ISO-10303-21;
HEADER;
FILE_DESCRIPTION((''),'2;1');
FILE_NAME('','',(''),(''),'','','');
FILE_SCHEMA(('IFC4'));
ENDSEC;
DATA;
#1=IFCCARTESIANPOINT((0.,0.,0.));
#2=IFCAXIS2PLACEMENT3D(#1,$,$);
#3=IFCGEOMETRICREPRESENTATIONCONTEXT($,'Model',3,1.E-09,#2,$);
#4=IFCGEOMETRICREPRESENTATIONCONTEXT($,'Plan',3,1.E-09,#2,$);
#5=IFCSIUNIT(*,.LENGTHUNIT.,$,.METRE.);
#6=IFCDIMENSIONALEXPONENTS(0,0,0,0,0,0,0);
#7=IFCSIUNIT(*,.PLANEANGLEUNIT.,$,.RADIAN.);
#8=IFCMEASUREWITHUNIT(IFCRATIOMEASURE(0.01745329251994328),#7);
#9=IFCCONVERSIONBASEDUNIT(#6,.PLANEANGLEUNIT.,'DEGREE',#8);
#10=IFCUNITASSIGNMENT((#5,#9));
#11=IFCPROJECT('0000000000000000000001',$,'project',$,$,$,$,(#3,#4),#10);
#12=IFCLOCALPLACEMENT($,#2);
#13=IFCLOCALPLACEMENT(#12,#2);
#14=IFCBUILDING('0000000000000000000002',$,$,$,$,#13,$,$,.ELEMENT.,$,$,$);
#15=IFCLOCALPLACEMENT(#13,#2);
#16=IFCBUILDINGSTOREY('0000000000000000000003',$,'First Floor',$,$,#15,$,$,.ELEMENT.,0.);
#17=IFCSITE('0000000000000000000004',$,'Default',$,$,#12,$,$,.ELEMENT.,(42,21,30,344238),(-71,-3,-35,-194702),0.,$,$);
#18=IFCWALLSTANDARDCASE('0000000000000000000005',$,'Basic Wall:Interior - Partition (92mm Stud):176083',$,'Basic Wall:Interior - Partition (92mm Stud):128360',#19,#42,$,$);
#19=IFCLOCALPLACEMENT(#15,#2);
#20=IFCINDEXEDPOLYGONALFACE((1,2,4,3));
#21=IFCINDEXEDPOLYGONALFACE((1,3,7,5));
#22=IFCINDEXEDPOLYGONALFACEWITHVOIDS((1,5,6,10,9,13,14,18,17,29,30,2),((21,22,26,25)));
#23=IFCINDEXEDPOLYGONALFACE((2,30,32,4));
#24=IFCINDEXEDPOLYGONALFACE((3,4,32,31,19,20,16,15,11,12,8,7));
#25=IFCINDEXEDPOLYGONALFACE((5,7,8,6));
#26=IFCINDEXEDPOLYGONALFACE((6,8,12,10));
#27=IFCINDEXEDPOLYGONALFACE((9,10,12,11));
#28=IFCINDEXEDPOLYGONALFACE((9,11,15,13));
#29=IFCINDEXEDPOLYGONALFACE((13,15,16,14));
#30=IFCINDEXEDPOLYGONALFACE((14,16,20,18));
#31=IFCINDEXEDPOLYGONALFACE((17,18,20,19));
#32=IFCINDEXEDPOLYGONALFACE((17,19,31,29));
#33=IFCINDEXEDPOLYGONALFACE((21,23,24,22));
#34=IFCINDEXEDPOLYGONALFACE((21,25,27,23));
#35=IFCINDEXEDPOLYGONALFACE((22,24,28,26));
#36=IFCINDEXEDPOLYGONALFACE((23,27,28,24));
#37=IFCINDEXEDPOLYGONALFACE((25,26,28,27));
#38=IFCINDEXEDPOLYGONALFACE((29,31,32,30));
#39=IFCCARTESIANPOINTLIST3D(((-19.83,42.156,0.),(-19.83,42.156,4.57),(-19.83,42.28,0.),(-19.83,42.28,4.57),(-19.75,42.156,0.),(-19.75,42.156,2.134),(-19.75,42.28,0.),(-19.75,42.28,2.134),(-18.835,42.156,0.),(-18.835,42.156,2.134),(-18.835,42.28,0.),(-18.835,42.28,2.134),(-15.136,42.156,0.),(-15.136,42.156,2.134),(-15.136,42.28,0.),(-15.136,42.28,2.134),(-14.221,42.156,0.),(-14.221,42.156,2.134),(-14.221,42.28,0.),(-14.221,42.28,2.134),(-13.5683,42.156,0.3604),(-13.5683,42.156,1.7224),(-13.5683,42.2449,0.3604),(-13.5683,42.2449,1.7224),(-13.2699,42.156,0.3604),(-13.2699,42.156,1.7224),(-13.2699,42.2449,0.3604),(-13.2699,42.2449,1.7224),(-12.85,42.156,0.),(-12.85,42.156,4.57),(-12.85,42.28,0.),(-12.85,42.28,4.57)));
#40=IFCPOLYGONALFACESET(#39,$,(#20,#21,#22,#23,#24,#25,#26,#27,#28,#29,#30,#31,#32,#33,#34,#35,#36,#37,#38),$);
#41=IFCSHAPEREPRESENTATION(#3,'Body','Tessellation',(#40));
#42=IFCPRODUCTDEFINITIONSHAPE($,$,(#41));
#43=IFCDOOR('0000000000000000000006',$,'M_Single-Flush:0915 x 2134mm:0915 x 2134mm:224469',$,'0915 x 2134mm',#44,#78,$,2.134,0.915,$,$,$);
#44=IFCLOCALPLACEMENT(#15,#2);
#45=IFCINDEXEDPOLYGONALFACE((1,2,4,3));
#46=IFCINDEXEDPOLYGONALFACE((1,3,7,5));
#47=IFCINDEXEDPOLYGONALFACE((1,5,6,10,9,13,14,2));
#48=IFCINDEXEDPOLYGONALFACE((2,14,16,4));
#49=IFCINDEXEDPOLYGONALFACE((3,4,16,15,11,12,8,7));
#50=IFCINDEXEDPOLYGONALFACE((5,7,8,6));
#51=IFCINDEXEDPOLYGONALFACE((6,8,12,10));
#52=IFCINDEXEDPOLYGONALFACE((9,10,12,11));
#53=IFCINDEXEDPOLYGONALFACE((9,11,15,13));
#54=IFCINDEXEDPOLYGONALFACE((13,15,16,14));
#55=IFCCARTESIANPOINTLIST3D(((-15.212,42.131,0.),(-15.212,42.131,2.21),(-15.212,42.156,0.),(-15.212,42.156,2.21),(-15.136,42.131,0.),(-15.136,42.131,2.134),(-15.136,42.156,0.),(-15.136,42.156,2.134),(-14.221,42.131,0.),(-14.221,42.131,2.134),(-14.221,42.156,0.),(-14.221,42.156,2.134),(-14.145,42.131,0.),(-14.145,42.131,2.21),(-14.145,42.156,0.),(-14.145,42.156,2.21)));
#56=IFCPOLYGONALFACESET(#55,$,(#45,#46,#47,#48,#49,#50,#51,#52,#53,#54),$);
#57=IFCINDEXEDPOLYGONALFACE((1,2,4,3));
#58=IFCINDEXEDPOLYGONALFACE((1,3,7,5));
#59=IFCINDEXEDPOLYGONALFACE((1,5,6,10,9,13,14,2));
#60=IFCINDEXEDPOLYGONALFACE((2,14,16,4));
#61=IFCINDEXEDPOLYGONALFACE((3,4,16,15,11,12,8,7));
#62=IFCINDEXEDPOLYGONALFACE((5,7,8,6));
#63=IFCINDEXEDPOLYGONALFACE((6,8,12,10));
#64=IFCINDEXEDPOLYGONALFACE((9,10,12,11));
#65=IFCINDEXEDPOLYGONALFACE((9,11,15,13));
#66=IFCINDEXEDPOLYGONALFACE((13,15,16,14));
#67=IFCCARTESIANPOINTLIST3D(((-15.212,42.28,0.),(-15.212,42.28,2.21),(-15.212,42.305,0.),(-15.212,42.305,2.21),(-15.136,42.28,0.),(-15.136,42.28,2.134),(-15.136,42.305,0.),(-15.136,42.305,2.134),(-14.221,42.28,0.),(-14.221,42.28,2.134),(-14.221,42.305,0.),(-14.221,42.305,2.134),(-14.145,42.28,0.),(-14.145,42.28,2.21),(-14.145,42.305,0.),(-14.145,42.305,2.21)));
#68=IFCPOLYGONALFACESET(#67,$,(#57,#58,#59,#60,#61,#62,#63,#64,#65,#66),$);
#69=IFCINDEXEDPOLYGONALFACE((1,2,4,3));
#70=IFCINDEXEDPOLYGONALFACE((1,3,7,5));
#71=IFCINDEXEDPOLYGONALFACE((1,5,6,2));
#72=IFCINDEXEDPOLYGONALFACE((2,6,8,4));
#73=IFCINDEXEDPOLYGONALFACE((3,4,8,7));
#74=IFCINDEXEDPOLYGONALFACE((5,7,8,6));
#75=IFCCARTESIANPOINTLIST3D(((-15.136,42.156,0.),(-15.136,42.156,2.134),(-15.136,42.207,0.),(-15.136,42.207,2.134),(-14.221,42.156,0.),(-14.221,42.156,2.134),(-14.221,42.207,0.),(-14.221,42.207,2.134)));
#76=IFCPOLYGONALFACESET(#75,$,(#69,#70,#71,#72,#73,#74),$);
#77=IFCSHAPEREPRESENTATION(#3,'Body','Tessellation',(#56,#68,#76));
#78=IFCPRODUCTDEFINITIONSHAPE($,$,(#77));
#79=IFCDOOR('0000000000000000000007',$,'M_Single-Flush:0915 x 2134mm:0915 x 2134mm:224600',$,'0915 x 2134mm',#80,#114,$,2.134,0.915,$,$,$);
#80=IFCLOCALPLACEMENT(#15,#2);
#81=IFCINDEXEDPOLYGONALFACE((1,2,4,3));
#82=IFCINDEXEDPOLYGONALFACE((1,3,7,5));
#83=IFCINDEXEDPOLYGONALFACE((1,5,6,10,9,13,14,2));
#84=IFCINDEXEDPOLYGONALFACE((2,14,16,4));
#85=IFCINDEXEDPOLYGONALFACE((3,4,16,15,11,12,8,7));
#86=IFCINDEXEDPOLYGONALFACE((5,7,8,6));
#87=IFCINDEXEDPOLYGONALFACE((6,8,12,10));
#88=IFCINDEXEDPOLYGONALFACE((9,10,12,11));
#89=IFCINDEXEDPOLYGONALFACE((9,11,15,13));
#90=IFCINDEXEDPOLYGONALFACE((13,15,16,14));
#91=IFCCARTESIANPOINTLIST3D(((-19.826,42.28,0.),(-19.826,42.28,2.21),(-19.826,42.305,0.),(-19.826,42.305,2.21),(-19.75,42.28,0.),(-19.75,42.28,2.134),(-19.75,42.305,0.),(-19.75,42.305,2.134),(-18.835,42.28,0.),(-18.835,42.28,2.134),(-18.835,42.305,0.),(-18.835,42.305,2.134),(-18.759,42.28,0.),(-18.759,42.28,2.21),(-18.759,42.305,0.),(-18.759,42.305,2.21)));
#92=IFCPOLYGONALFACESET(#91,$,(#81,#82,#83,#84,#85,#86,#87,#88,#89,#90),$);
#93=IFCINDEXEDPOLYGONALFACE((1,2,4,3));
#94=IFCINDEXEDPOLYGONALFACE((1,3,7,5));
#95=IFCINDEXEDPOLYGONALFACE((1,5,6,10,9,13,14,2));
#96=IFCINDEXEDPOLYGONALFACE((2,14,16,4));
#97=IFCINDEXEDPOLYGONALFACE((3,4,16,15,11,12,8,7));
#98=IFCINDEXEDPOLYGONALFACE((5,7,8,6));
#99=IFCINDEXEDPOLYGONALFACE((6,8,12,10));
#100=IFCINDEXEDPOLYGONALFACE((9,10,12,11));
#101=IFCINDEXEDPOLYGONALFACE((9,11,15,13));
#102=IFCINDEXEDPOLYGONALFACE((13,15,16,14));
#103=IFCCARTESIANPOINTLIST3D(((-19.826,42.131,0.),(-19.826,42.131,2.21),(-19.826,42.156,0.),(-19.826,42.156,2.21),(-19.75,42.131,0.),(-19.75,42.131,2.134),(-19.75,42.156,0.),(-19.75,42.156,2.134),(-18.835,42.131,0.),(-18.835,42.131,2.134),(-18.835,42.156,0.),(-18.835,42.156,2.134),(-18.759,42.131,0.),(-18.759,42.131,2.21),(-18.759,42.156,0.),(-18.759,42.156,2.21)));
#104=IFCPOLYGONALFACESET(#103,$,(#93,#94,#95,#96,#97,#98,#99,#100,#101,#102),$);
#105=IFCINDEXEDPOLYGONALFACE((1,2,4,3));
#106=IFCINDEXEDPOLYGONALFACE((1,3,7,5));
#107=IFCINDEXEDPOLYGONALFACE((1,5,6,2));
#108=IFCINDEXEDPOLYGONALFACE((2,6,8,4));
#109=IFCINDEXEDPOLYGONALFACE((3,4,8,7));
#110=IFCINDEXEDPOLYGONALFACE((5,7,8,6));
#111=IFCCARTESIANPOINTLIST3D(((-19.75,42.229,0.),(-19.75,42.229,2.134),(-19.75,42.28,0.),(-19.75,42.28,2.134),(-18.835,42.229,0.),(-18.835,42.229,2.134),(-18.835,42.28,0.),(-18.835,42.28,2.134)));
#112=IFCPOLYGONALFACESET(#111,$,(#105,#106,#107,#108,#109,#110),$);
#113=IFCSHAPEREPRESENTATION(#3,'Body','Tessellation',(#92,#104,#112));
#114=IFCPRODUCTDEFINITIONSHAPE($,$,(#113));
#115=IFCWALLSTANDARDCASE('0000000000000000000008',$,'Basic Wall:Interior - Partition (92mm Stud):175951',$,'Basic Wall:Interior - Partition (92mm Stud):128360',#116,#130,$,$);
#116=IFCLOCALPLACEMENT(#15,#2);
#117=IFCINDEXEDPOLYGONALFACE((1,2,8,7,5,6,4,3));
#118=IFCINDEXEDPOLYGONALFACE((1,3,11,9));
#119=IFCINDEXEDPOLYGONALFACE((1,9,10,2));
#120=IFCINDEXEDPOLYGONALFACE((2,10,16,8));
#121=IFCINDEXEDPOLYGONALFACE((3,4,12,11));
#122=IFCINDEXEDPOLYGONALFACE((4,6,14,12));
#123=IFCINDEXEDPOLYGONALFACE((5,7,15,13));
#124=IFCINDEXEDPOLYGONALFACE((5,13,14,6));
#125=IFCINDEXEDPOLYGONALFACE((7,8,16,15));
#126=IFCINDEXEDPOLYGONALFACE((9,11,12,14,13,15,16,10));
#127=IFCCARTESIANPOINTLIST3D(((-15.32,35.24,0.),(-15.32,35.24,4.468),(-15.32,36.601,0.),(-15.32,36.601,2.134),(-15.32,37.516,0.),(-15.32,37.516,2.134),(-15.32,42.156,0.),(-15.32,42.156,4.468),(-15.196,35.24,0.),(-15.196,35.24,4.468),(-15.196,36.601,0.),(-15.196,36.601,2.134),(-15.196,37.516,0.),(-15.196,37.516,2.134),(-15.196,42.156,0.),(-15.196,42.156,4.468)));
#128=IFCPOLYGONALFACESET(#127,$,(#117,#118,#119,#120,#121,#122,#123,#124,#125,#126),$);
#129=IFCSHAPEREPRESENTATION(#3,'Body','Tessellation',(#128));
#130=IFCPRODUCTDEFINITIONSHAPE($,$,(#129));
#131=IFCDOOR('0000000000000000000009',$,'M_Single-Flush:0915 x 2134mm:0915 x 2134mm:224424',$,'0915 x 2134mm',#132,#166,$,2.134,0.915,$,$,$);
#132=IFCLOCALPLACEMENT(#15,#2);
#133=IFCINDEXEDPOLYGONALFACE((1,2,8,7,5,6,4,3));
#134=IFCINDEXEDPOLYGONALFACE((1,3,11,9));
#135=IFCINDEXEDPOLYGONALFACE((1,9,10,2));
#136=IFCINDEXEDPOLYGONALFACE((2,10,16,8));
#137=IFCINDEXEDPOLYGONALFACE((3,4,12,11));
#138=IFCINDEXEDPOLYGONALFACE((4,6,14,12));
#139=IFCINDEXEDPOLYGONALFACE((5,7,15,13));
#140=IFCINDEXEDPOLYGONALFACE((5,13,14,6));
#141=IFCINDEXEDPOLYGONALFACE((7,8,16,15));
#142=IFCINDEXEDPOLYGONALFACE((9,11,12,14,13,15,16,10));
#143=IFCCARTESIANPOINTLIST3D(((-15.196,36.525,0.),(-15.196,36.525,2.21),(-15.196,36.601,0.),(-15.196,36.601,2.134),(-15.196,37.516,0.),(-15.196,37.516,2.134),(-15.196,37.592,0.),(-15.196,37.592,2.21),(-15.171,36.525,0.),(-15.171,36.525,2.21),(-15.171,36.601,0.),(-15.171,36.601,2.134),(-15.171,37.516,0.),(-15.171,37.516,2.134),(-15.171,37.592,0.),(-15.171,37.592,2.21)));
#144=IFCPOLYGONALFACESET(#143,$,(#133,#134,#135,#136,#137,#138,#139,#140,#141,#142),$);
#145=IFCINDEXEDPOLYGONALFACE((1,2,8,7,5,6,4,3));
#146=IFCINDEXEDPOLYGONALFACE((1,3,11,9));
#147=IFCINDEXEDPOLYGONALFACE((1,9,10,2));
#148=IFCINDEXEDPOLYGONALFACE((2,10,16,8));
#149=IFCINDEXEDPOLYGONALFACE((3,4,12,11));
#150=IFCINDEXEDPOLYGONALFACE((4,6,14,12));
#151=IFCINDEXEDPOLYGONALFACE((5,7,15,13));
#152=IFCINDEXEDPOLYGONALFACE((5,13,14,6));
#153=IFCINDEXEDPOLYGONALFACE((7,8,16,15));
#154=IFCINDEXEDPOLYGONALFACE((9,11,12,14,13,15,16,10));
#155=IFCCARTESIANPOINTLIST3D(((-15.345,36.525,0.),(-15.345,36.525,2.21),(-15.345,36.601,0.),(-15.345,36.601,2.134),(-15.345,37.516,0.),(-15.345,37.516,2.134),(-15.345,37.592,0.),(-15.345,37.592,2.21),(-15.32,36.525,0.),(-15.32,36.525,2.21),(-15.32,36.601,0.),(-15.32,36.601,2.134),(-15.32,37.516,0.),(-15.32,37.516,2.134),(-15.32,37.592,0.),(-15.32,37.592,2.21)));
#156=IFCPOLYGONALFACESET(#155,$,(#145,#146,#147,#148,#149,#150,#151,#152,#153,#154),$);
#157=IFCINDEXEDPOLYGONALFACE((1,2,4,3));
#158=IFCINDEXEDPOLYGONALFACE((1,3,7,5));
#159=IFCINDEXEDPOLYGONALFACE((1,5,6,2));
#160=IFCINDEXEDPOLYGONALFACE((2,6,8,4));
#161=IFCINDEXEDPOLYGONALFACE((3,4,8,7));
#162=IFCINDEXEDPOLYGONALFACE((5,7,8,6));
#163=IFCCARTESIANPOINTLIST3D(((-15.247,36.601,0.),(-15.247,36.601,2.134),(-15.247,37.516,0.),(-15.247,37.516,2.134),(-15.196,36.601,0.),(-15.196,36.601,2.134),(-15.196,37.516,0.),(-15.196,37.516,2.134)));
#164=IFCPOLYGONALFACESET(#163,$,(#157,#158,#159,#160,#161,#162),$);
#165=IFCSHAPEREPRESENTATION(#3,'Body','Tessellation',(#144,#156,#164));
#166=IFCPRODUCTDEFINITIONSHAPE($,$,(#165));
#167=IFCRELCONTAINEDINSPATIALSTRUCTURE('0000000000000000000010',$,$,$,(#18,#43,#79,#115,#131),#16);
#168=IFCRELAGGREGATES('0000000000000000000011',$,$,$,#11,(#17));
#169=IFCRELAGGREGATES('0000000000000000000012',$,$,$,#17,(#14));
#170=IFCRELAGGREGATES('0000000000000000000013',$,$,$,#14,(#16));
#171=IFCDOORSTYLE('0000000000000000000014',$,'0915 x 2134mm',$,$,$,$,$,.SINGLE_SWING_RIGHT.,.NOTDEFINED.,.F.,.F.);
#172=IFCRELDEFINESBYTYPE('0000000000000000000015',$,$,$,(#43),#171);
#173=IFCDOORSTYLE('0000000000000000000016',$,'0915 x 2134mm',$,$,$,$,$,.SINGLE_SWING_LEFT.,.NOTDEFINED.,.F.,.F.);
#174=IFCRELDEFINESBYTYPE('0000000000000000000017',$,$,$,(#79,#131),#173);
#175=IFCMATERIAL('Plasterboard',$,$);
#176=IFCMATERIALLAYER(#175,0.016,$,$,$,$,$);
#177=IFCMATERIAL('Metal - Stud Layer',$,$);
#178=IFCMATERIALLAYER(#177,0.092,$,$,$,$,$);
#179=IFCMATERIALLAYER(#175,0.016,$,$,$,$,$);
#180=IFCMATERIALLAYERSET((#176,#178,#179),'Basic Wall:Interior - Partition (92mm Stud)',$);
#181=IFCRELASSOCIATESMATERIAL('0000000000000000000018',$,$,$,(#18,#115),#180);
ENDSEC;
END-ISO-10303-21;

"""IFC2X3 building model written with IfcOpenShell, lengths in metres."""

from ifc_helpers import new_model, entity, si_unit, converted_unit, frame, frame_2d, origin, origin_2d_with_axis, place, context, project, spatial, polyline, rectangle, outline, extrude, source, transform, mapped, material, layer, layer_set, layer_usage, type_object, type_shapes, element, fill, save


model = new_model("IFC2X3")

# Units and contexts
model_context = context("Model", 3, precision=1e-09, world=origin())
plan_context = context("Plan", 3, precision=1e-09, world=origin())
ifc_project = project(units=[si_unit("LENGTHUNIT", "METRE"), converted_unit("PLANEANGLEUNIT", "DEGREE", entity("IfcRatioMeasure", 0.01745329251994328), si_unit("PLANEANGLEUNIT", "RADIAN"), dimensions=[0, 0, 0, 0, 0, 0, 0])], contexts=[model_context, plan_context])

# Site, building, storey
site_placement = place(None, origin())
site = spatial("IfcSite", under=ifc_project, at=site_placement, Name="Default", CompositionType="ELEMENT", RefLatitude=(42, 21, 30, 344238), RefLongitude=(-71, -3, -35, -194702), RefElevation=0.0)
building_placement = place(site_placement, origin())
building = spatial("IfcBuilding", under=site, at=building_placement, CompositionType="ELEMENT")
storey_placement = place(building_placement, origin())
storey = spatial("IfcBuildingStorey", under=building, at=storey_placement, Name="First Floor", CompositionType="ELEMENT", Elevation=0.0)

# Wall, openings, doors
ifc_material_1 = material(Name="Plasterboard")
ifc_layer_1 = layer(ifc_material_1, 0.016)
ifc_material_2 = material(Name="Metal - Stud Layer")
ifc_layer_2 = layer(ifc_material_2, 0.092)
ifc_layer_3 = layer(ifc_material_1, 0.016)
ifc_layer_set_1 = layer_set([ifc_layer_1, ifc_layer_2, ifc_layer_3], Name="Basic Wall:Interior - Partition (92mm Stud)")
ifc_layer_usage_1 = layer_usage(ifc_layer_set_1, "AXIS2", "NEGATIVE", 0.062)
door_style_1 = type_object("IfcDoorStyle", Name="0915 x 2134mm", ConstructionType="NOTDEFINED", OperationType="SINGLE_SWING_RIGHT", ParameterTakesPrecedence=False, Sizeable=False)
shared_shape_1 = source(origin(), model_context, "Body", "SweptSolid", [
    extrude(outline(polyline([(-0.5335, -1.124), (0.5335, -1.124), (0.5335, 1.086), (0.4575, 1.086), (0.4575, -1.048), (-0.4575, -1.048), (-0.4575, 1.086), (-0.5335, 1.086), (-0.5335, -1.124)])), frame((0.4575, 0.124, 1.086), z_axis=(0.0, 1.0, 0.0), x_axis=(1.0, 0.0, 0.0)), (0.0, 0.0, 1.0), 0.025),
    extrude(outline(polyline([(-1.124, -0.5335), (1.086, -0.5335), (1.086, -0.4575), (-1.048, -0.4575), (-1.048, 0.4575), (1.086, 0.4575), (1.086, 0.5335), (-1.124, 0.5335), (-1.124, -0.5335)])), frame((0.4575, -0.025, 1.086), z_axis=(0.0, 1.0, 0.0), x_axis=(0.0, 0.0, -1.0)), (0.0, 0.0, 1.0), 0.025),
    extrude(rectangle(XDim=0.051, YDim=0.915, at=origin_2d_with_axis()), frame((0.4575, 0.0985, 0.0), z_axis=(0.0, 0.0, 1.0), x_axis=(0.0, 1.0, 0.0)), (0.0, 0.0, 1.0), 2.134),
])
type_shapes(door_style_1, [shared_shape_1])
door_style_2 = type_object("IfcDoorStyle", Name="0915 x 2134mm", ConstructionType="NOTDEFINED", OperationType="SINGLE_SWING_LEFT", ParameterTakesPrecedence=False, Sizeable=False)
shared_shape_2 = source(origin(), model_context, "Body", "SweptSolid", [
    extrude(outline(polyline([(-0.5335, -1.124), (0.5335, -1.124), (0.5335, 1.086), (0.4575, 1.086), (0.4575, -1.048), (-0.4575, -1.048), (-0.4575, 1.086), (-0.5335, 1.086), (-0.5335, -1.124)])), frame((0.4575, 0.149, 1.086), z_axis=(0.0, -1.0, 0.0), x_axis=(-1.0, 0.0, 0.0)), (0.0, 0.0, 1.0), 0.025),
    extrude(outline(polyline([(-1.124, -0.5335), (1.086, -0.5335), (1.086, -0.4575), (-1.048, -0.4575), (-1.048, 0.4575), (1.086, 0.4575), (1.086, 0.5335), (-1.124, 0.5335), (-1.124, -0.5335)])), frame((0.4575, 0.0, 1.086), z_axis=(0.0, -1.0, 0.0), x_axis=(0.0, 0.0, -1.0)), (0.0, 0.0, 1.0), 0.025),
    extrude(rectangle(XDim=0.915, YDim=0.051, at=origin_2d_with_axis()), frame((0.4575, 0.0985, 0.0)), (0.0, 0.0, 1.0), 2.134),
])
type_shapes(door_style_2, [shared_shape_2])
wall_1_placement = place(storey_placement, frame((-19.83, 42.218, 0.0)))
wall_1 = element("IfcWallStandardCase", 1, at=wall_1_placement, inside=storey, material=ifc_layer_usage_1, Name="Basic Wall:Interior - Partition (92mm Stud):176083", ObjectType="Basic Wall:Interior - Partition (92mm Stud):128360", context=model_context, shape_type="SweptSolid", body=[
    extrude(rectangle(XDim=6.98, YDim=0.124, at=frame_2d((3.49, 0.0), x_axis=(-1.0, 0.0))), origin(), (0.0, 0.0, 1.0), 4.57),
])
opening_1_placement = place(wall_1_placement, origin())
element("IfcOpeningElement", 2, at=opening_1_placement, cuts=wall_1, ObjectType="Opening", context=model_context, shape_type="SweptSolid", body=[
    extrude(rectangle(XDim=1.3621, YDim=0.2984, at=origin_2d_with_axis()), frame((6.4109, -0.1255, 1.0414), z_axis=(0.0, 1.0, 0.0), x_axis=(0.0, 0.0, -1.0)), (0.0, 0.0, 1.0), 0.1524),
])
opening_2_placement = place(wall_1_placement, frame((5.609, 0.062, 0.0)))
opening_2 = element("IfcOpeningElement", 3, at=opening_2_placement, cuts=wall_1, ObjectType="Opening", context=model_context, shape_type="SweptSolid", body=[
    extrude(rectangle(XDim=0.915, YDim=2.134, at=frame_2d((1.067, 0.4575), x_axis=(0.0, 1.0))), frame((0.0, 0.0, 0.0), z_axis=(0.0, -1.0, 0.0), x_axis=(0.0, 0.0, 1.0)), (0.0, 0.0, 1.0), 0.124),
])
opening_3_placement = place(wall_1_placement, frame((0.08, -0.062, 0.0)))
opening_3 = element("IfcOpeningElement", 4, at=opening_3_placement, cuts=wall_1, ObjectType="Opening", context=model_context, shape_type="SweptSolid", body=[
    extrude(rectangle(XDim=0.915, YDim=2.134, at=frame_2d((1.067, 0.4575), x_axis=(0.0, -1.0))), frame((0.0, 0.0, 0.0), z_axis=(0.0, 1.0, 0.0), x_axis=(0.0, 0.0, 1.0)), (0.0, 0.0, 1.0), 0.124),
])
door_1_placement = place(opening_2_placement, frame((0.0, 0.0, 0.0), z_axis=(0.0, 0.0, 1.0), x_axis=(-1.0, 0.0, 0.0)))
door_1 = element("IfcDoor", 5, at=door_1_placement, inside=storey, type_object=door_style_1, Name="M_Single-Flush:0915 x 2134mm:0915 x 2134mm:224469", ObjectType="0915 x 2134mm", OverallHeight=2.134, OverallWidth=0.915, context=model_context, shape_type="MappedRepresentation", body=[
    mapped(shared_shape_1, transform((0.0, 0.0, 0.0), scale=1.0)),
])
fill(opening_2, door_1)
door_2_placement = place(opening_3_placement, origin())
door_2 = element("IfcDoor", 6, at=door_2_placement, inside=storey, type_object=door_style_2, Name="M_Single-Flush:0915 x 2134mm:0915 x 2134mm:224600", ObjectType="0915 x 2134mm", OverallHeight=2.134, OverallWidth=0.915, context=model_context, shape_type="MappedRepresentation", body=[
    mapped(shared_shape_2, transform((0.0, 0.0, 0.0), scale=1.0)),
])
fill(opening_3, door_2)

# Wall, opening, door
wall_2_placement = place(storey_placement, frame((-15.258, 35.24, 0.0), z_axis=(0.0, 0.0, 1.0), x_axis=(0.0, 1.0, 0.0)))
wall_2 = element("IfcWallStandardCase", 7, at=wall_2_placement, inside=storey, material=ifc_layer_usage_1, Name="Basic Wall:Interior - Partition (92mm Stud):175951", ObjectType="Basic Wall:Interior - Partition (92mm Stud):128360", context=model_context, shape_type="SweptSolid", body=[
    extrude(rectangle(XDim=6.916, YDim=0.124, at=frame_2d((3.458, 0.0), x_axis=(-1.0, 0.0))), origin(), (0.0, 0.0, 1.0), 4.468),
])
opening_4_placement = place(wall_2_placement, frame((2.276, 0.062, 0.0)))
opening_4 = element("IfcOpeningElement", 8, at=opening_4_placement, cuts=wall_2, ObjectType="Opening", context=model_context, shape_type="SweptSolid", body=[
    extrude(rectangle(XDim=0.915, YDim=2.134, at=frame_2d((1.067, 0.4575), x_axis=(0.0, -1.0))), frame((0.0, 0.0, 0.0), z_axis=(0.0, -1.0, 0.0), x_axis=(0.0, 0.0, 1.0)), (0.0, 0.0, 1.0), 0.124),
])
door_3_placement = place(opening_4_placement, frame((0.0, 0.0, 0.0), z_axis=(0.0, 0.0, 1.0), x_axis=(-1.0, 0.0, 0.0)))
door_3 = element("IfcDoor", 9, at=door_3_placement, inside=storey, type_object=door_style_2, Name="M_Single-Flush:0915 x 2134mm:0915 x 2134mm:224424", ObjectType="0915 x 2134mm", OverallHeight=2.134, OverallWidth=0.915, context=model_context, shape_type="MappedRepresentation", body=[
    mapped(shared_shape_2, transform((0.0, 0.0, 0.0), scale=1.0)),
])
fill(opening_4, door_3)

save(model, "model.ifc")
